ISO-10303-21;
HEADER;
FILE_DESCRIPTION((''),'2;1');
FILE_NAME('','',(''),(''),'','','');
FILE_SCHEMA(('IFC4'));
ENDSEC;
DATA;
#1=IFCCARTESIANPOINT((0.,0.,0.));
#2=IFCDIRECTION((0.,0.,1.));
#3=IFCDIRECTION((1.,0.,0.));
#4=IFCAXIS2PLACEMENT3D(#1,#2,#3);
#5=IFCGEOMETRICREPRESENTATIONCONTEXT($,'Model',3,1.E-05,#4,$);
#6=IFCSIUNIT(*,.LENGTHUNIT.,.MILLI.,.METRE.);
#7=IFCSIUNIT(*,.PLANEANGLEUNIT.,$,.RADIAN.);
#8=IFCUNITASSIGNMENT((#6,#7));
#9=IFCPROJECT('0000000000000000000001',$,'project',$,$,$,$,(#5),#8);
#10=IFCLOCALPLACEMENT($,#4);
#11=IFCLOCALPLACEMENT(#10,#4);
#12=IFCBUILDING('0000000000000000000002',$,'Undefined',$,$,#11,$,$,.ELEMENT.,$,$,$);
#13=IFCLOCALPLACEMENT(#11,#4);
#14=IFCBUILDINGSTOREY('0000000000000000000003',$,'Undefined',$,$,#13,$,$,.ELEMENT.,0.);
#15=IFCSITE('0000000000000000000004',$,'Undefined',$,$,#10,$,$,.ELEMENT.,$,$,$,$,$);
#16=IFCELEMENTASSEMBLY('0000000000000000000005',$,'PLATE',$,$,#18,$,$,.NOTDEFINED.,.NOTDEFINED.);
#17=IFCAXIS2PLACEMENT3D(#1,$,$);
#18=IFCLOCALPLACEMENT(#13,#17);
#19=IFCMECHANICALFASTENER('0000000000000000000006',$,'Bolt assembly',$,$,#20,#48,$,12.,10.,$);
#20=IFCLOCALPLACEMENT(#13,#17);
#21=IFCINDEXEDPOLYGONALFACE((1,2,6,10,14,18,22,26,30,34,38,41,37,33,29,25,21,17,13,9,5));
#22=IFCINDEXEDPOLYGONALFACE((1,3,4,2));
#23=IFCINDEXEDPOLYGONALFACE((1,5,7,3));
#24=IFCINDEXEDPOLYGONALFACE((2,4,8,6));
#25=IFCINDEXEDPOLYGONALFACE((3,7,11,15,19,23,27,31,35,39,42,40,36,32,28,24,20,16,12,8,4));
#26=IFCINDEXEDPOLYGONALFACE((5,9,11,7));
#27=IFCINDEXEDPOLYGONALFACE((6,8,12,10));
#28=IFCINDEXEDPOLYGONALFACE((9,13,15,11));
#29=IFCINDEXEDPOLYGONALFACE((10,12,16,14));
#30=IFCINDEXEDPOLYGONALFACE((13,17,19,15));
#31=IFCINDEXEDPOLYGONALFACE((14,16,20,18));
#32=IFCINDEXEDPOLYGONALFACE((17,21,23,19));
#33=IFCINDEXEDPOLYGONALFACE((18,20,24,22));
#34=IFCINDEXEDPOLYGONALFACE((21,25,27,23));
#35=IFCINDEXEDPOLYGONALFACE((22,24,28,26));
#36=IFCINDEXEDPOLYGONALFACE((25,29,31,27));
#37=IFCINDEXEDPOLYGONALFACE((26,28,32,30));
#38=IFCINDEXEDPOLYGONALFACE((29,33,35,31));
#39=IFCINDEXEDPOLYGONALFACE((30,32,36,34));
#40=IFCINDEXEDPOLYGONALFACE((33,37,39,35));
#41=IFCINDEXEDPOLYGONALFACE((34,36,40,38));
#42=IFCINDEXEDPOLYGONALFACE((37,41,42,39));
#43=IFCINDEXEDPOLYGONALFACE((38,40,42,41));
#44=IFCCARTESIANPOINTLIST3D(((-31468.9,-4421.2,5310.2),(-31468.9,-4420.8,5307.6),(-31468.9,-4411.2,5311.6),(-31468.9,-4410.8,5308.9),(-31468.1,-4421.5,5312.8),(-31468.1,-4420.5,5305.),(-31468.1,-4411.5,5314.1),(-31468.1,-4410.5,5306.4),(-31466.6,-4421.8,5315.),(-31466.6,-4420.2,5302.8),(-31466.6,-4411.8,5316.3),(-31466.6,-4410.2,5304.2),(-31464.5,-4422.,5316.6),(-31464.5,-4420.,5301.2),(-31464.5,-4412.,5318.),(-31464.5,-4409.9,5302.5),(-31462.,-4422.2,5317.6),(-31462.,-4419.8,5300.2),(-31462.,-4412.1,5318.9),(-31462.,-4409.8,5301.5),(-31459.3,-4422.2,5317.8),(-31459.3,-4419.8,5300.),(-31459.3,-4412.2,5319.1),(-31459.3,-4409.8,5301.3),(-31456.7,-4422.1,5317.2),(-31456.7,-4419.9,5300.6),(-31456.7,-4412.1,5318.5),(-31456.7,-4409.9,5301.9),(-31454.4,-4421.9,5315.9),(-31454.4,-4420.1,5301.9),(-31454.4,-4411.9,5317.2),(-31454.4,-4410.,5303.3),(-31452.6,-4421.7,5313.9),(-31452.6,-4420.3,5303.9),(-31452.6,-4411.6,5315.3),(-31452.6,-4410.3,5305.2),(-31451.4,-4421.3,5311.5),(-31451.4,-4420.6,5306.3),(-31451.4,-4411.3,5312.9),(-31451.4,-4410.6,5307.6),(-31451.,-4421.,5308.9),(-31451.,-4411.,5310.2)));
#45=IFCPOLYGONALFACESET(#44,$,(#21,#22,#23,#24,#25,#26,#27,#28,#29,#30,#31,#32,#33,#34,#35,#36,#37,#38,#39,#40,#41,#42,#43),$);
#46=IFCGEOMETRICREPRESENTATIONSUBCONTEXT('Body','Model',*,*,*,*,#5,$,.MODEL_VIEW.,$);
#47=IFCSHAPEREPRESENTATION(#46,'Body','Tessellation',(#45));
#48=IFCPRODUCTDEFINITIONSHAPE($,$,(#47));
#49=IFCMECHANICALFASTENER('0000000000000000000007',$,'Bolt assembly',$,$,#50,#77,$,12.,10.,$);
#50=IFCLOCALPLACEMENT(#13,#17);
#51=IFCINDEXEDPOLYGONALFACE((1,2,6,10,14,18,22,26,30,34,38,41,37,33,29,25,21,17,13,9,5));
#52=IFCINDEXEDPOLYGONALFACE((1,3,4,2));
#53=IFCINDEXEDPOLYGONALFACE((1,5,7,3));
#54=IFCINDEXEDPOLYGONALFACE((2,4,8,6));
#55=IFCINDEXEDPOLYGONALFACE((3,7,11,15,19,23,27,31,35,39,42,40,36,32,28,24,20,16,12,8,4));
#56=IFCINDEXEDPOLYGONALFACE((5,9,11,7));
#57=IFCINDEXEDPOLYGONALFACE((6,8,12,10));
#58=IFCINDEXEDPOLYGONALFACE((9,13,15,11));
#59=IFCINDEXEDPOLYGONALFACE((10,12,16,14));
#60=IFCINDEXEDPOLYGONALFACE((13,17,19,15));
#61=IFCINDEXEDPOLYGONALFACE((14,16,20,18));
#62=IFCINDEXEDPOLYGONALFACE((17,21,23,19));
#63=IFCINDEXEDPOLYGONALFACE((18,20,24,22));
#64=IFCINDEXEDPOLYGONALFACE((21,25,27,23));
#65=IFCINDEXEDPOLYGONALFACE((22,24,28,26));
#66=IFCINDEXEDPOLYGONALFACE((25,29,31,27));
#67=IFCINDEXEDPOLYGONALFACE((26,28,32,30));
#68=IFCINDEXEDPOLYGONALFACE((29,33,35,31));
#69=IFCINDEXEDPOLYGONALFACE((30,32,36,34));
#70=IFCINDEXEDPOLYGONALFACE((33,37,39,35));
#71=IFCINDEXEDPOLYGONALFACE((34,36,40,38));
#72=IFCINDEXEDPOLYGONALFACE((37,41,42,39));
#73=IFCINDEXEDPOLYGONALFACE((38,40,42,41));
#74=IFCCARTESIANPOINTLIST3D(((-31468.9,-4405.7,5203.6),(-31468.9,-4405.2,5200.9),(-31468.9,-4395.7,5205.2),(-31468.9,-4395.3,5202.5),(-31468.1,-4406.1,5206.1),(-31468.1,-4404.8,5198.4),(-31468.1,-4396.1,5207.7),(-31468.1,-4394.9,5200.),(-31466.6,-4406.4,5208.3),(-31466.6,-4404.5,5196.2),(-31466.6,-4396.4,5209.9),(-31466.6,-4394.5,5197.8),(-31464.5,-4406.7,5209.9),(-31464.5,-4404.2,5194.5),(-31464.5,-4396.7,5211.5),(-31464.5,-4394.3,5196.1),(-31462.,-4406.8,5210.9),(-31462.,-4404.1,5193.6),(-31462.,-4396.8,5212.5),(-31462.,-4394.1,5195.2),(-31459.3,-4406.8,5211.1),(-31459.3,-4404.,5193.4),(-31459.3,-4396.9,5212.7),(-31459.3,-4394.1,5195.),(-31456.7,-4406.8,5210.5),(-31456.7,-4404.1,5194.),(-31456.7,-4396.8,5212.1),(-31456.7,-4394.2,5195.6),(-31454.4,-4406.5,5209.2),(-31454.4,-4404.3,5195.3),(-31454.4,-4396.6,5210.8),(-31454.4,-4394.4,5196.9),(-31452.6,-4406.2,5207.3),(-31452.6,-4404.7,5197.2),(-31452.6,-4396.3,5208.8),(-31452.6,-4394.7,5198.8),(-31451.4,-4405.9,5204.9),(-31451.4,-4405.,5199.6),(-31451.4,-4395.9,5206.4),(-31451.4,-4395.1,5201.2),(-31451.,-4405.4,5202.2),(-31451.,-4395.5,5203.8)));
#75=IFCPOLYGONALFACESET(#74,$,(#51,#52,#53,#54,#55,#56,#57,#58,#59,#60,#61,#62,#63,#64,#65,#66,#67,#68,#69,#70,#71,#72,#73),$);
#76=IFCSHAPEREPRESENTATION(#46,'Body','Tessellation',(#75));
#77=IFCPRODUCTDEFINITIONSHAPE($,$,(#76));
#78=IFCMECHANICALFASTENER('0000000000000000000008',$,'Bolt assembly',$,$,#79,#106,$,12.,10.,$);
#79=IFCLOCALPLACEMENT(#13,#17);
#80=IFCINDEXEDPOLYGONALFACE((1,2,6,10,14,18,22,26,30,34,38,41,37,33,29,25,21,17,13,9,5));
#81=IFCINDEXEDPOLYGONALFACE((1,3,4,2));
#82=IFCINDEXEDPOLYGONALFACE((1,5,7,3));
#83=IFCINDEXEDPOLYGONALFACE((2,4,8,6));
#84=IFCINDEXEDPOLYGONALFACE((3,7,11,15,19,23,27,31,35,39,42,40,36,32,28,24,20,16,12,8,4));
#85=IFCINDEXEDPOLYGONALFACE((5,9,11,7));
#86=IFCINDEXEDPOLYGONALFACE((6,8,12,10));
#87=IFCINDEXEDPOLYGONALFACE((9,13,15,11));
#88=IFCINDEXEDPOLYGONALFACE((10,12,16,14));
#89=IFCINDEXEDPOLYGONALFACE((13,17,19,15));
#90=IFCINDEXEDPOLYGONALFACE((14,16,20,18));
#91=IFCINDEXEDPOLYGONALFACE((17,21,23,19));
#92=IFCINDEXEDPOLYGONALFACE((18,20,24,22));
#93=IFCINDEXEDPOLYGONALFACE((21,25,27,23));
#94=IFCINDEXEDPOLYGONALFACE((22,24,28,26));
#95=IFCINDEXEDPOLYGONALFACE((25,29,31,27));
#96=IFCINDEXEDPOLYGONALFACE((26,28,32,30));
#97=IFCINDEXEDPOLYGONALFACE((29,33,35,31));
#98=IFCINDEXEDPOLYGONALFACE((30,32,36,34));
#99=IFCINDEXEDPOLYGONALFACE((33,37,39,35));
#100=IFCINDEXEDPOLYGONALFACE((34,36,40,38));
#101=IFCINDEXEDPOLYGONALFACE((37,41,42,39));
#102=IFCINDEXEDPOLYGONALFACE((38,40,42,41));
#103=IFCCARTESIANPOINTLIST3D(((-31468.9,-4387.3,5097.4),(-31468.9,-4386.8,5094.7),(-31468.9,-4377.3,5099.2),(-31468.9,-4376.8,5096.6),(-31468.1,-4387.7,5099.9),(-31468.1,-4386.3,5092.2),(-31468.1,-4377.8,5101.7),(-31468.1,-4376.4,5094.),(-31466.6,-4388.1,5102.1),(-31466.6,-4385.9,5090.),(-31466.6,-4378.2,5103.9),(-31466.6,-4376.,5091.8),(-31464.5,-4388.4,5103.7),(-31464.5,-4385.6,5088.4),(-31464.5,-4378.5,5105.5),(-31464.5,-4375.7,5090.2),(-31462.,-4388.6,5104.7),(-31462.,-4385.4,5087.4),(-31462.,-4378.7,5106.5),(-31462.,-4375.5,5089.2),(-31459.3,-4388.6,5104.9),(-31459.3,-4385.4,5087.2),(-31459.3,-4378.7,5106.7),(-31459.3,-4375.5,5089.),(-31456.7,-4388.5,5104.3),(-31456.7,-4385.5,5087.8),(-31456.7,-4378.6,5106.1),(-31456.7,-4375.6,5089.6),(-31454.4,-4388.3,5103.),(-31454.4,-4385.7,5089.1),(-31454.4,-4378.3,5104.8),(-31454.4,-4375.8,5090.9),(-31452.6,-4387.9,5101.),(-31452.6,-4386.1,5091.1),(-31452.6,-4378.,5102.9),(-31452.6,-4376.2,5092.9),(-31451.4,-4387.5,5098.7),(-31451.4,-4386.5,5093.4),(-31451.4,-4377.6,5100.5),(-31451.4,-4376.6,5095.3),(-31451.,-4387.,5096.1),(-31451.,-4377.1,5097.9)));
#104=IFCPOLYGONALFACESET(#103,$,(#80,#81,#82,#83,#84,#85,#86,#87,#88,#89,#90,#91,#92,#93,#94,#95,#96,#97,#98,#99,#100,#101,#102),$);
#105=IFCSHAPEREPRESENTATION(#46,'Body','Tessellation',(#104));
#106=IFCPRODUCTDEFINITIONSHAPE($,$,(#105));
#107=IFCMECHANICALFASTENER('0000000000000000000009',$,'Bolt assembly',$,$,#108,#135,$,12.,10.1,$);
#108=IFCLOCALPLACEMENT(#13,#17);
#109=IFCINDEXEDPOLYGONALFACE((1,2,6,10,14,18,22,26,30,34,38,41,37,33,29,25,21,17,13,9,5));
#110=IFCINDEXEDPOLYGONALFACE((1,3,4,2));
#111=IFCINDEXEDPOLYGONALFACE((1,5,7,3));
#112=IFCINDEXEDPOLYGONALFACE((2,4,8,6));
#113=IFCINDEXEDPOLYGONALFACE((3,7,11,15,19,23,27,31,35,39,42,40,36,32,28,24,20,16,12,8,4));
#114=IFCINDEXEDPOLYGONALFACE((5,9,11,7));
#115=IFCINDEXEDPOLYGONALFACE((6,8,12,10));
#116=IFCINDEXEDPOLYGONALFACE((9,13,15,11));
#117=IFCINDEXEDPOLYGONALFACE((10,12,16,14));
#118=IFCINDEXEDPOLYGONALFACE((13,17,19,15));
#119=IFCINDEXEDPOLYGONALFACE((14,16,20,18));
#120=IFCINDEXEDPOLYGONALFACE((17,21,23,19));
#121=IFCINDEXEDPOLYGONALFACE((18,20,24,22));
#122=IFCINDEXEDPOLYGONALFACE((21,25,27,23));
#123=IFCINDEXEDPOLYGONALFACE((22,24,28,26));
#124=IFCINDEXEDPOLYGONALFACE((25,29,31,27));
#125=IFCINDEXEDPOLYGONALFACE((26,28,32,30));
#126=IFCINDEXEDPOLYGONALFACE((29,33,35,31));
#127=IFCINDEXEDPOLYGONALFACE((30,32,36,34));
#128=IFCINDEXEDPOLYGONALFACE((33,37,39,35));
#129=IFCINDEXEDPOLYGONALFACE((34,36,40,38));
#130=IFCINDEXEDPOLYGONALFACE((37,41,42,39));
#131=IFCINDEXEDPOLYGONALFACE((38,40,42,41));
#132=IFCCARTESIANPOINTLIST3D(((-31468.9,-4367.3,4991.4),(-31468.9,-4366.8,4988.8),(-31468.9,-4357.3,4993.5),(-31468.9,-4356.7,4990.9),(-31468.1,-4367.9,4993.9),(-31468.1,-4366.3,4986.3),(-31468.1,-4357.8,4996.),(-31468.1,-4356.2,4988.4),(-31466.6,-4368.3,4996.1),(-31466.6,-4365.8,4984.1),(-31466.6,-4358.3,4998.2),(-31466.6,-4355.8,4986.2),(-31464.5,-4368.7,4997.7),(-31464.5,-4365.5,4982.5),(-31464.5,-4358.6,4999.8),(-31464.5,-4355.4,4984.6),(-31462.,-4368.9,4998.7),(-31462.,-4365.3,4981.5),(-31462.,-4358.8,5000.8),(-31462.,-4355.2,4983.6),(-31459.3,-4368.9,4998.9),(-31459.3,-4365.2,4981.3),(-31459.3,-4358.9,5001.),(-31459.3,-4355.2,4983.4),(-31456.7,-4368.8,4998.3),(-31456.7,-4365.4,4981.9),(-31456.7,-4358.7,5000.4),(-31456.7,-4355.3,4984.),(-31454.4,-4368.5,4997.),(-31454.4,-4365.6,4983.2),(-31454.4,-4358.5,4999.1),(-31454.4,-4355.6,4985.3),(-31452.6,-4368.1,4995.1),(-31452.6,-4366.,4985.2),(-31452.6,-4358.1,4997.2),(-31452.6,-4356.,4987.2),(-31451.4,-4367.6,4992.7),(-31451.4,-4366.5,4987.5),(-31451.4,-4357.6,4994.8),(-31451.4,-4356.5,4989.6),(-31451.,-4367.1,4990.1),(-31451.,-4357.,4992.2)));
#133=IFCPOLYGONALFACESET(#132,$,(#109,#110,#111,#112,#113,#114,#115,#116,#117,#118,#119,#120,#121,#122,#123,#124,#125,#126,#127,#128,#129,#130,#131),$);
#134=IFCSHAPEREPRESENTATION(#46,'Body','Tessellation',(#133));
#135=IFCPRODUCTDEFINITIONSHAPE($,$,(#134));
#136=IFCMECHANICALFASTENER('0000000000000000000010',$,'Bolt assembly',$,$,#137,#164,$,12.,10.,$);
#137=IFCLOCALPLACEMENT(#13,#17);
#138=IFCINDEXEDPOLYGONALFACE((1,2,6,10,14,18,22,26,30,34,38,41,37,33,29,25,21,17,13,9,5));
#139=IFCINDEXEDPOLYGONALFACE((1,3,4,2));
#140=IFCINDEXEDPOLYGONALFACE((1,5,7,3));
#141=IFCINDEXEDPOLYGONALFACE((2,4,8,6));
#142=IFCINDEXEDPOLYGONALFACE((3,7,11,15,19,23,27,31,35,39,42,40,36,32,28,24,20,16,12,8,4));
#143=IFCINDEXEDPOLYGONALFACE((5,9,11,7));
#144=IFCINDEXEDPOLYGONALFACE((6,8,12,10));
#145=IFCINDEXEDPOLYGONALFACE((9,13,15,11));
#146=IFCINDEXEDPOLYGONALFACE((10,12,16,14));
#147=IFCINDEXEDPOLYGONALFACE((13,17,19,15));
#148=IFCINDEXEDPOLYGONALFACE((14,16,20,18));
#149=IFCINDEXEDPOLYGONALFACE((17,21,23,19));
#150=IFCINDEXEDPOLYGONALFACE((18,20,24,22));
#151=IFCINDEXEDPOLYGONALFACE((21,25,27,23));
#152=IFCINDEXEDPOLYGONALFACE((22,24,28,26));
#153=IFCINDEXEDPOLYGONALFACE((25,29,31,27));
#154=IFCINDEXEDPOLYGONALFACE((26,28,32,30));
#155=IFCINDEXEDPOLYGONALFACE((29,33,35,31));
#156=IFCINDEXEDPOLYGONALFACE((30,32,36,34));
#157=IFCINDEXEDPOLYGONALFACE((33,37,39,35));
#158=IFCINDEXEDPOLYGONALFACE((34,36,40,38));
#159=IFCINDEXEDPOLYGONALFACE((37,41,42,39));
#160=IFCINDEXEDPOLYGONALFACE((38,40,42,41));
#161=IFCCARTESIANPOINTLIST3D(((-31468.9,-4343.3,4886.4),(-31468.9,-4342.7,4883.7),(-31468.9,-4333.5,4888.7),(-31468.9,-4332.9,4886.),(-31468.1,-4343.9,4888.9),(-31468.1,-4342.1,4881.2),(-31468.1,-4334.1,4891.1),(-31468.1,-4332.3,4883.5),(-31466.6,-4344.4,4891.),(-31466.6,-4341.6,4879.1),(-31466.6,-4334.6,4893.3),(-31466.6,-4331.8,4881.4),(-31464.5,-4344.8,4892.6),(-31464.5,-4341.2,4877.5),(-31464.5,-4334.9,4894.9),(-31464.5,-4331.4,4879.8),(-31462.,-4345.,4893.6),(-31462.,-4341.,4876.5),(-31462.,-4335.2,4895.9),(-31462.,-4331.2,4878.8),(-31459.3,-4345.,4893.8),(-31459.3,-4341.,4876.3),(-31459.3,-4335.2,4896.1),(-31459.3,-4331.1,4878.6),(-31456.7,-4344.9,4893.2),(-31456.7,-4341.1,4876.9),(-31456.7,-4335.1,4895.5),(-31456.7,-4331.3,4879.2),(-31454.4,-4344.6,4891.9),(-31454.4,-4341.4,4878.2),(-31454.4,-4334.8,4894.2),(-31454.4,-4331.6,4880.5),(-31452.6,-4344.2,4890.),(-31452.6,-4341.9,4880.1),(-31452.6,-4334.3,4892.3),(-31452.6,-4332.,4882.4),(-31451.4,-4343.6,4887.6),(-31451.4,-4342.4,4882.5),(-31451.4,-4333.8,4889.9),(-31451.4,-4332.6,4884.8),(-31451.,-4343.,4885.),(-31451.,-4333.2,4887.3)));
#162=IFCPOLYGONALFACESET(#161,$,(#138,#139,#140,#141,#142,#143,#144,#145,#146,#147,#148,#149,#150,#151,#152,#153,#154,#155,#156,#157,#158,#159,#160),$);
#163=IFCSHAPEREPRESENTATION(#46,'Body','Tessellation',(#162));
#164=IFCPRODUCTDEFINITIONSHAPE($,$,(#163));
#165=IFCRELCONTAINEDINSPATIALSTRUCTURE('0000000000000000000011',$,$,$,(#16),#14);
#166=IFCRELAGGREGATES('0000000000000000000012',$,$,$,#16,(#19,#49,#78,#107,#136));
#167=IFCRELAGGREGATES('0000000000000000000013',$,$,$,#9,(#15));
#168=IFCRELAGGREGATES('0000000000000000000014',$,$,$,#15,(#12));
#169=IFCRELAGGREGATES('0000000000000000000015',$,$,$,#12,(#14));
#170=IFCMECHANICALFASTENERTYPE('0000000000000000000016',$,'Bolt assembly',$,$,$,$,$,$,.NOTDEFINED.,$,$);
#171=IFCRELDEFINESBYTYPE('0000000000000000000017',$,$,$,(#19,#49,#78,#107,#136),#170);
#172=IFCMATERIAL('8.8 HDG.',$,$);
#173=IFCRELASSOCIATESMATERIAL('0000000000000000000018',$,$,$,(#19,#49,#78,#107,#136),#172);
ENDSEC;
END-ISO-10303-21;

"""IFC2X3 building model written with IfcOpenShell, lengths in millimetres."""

from ifc_helpers import new_model, si_unit, frame, origin_with_axes, origin_2d_with_axis, place, context, subcontext, project, spatial, circle, extrude, source, transform, mapped, material, type_object, element, aggregate, save


model = new_model("IFC2X3")

# Units and contexts
model_context = context("Model", 3, precision=1e-05, world=origin_with_axes())
body_context = subcontext(model_context, "Body", "Model", "MODEL_VIEW")
ifc_project = project(units=[si_unit("LENGTHUNIT", "METRE", prefix="MILLI"), si_unit("PLANEANGLEUNIT", "RADIAN")], contexts=[model_context])

# Site, building, storey
site_placement = place(None, origin_with_axes())
site = spatial("IfcSite", under=ifc_project, at=site_placement, Name="Undefined", CompositionType="ELEMENT")
building_placement = place(site_placement, origin_with_axes())
building = spatial("IfcBuilding", under=site, at=building_placement, Name="Undefined", CompositionType="ELEMENT")
storey_placement = place(building_placement, origin_with_axes())
storey = spatial("IfcBuildingStorey", under=building, at=storey_placement, Name="Undefined", CompositionType="ELEMENT", Elevation=0.0)

# Element assembly
assembly_1_placement = place(storey_placement, origin_with_axes())
assembly_1 = element("IfcElementAssembly", 1, at=assembly_1_placement, inside=storey, Name="PLATE", AssemblyPlace="NOTDEFINED", PredefinedType="NOTDEFINED")

# Shared definitions
mechanical_fastener_type = type_object("IfcMechanicalFastenerType", Name="Bolt assembly")

# Mechanical fasteners
ifc_material_1 = material(Name="8.8 HDG.")
shared_shape_1 = source(origin_with_axes(), body_context, "Body", "SweptSolid", [
    extrude(circle(Radius=9.0, at=origin_2d_with_axis()), frame((0.0, 0.6, 0.0), z_axis=(0.0, 1.0, 0.0), x_axis=(1.0, 0.0, 0.0)), (0.0, 0.0, 1.0), 10.1),
])
mechanical_fastener_1_placement = place(assembly_1_placement, frame((-31460.0, -4421.6, 5308.8), z_axis=(0.000001, -0.132523, 0.99118), x_axis=(1.0, 0.0, -0.000001)))
mechanical_fastener_1 = element("IfcMechanicalFastener", 2, at=mechanical_fastener_1_placement, type_object=mechanical_fastener_type, material=ifc_material_1, Name="Bolt assembly", NominalDiameter=12.0, NominalLength=10.0, context=body_context, shape_type="MappedRepresentation", body=[
    mapped(shared_shape_1, transform((0.0, 0.0, 0.0))),
])
shared_shape_2 = source(origin_with_axes(), body_context, "Body", "SweptSolid", [
    extrude(circle(Radius=9.0, at=origin_2d_with_axis()), frame((0.0, 0.6, 0.0), z_axis=(0.0, 1.0, 0.0), x_axis=(1.0, 0.0, 0.0)), (0.0, 0.0, 1.0), 10.1),
])
mechanical_fastener_2_placement = place(assembly_1_placement, frame((-31460.0, -4406.0, 5202.2), z_axis=(0.000001, -0.156435, 0.987688), x_axis=(1.0, 0.0, -0.000001)))
mechanical_fastener_2 = element("IfcMechanicalFastener", 3, at=mechanical_fastener_2_placement, type_object=mechanical_fastener_type, material=ifc_material_1, Name="Bolt assembly", NominalDiameter=12.0, NominalLength=10.0, context=body_context, shape_type="MappedRepresentation", body=[
    mapped(shared_shape_2, transform((0.0, 0.0, 0.0))),
])
shared_shape_3 = source(origin_with_axes(), body_context, "Body", "SweptSolid", [
    extrude(circle(Radius=9.0, at=origin_2d_with_axis()), frame((0.0, 0.9, 0.0), z_axis=(0.0, 1.0, 0.0), x_axis=(1.0, 0.0, 0.0)), (0.0, 0.0, 1.0), 10.1),
])
mechanical_fastener_3_placement = place(assembly_1_placement, frame((-31460.0, -4387.9, 5095.9), z_axis=(0.000001, -0.180255, 0.98362), x_axis=(1.0, 0.0, -0.000001)))
mechanical_fastener_3 = element("IfcMechanicalFastener", 4, at=mechanical_fastener_3_placement, type_object=mechanical_fastener_type, material=ifc_material_1, Name="Bolt assembly", NominalDiameter=12.0, NominalLength=10.0, context=body_context, shape_type="MappedRepresentation", body=[
    mapped(shared_shape_3, transform((0.0, 0.0, 0.0))),
])
shared_shape_4 = source(origin_with_axes(), body_context, "Body", "SweptSolid", [
    extrude(circle(Radius=9.0, at=origin_2d_with_axis()), frame((0.0, 0.1, 0.0), z_axis=(0.0, 1.0, 0.0), x_axis=(1.0, 0.0, 0.0)), (0.0, 0.0, 1.0), 10.3),
])
mechanical_fastener_4_placement = place(assembly_1_placement, frame((-31460.0, -4367.2, 4990.1), z_axis=(0.000001, -0.203971, 0.978977), x_axis=(1.0, 0.0, -0.000001)))
mechanical_fastener_4 = element("IfcMechanicalFastener", 5, at=mechanical_fastener_4_placement, type_object=mechanical_fastener_type, material=ifc_material_1, Name="Bolt assembly", NominalDiameter=12.0, NominalLength=10.1, context=body_context, shape_type="MappedRepresentation", body=[
    mapped(shared_shape_4, transform((0.0, 0.0, 0.0))),
])
shared_shape_5 = source(origin_with_axes(), body_context, "Body", "SweptSolid", [
    extrude(circle(Radius=9.0, at=origin_2d_with_axis()), frame((0.0, 0.9, 0.0), z_axis=(0.0, 1.0, 0.0), x_axis=(1.0, 0.0, 0.0)), (0.0, 0.0, 1.0), 10.1),
])
mechanical_fastener_5_placement = place(assembly_1_placement, frame((-31460.0, -4343.9, 4884.8), z_axis=(0.000001, -0.227567, 0.973762), x_axis=(1.0, 0.0, -0.000001)))
mechanical_fastener_5 = element("IfcMechanicalFastener", 6, at=mechanical_fastener_5_placement, type_object=mechanical_fastener_type, material=ifc_material_1, Name="Bolt assembly", NominalDiameter=12.0, NominalLength=10.0, context=body_context, shape_type="MappedRepresentation", body=[
    mapped(shared_shape_5, transform((0.0, 0.0, 0.0))),
])
aggregate(assembly_1, [mechanical_fastener_1, mechanical_fastener_2, mechanical_fastener_3, mechanical_fastener_4, mechanical_fastener_5])

save(model, "model.ifc")
